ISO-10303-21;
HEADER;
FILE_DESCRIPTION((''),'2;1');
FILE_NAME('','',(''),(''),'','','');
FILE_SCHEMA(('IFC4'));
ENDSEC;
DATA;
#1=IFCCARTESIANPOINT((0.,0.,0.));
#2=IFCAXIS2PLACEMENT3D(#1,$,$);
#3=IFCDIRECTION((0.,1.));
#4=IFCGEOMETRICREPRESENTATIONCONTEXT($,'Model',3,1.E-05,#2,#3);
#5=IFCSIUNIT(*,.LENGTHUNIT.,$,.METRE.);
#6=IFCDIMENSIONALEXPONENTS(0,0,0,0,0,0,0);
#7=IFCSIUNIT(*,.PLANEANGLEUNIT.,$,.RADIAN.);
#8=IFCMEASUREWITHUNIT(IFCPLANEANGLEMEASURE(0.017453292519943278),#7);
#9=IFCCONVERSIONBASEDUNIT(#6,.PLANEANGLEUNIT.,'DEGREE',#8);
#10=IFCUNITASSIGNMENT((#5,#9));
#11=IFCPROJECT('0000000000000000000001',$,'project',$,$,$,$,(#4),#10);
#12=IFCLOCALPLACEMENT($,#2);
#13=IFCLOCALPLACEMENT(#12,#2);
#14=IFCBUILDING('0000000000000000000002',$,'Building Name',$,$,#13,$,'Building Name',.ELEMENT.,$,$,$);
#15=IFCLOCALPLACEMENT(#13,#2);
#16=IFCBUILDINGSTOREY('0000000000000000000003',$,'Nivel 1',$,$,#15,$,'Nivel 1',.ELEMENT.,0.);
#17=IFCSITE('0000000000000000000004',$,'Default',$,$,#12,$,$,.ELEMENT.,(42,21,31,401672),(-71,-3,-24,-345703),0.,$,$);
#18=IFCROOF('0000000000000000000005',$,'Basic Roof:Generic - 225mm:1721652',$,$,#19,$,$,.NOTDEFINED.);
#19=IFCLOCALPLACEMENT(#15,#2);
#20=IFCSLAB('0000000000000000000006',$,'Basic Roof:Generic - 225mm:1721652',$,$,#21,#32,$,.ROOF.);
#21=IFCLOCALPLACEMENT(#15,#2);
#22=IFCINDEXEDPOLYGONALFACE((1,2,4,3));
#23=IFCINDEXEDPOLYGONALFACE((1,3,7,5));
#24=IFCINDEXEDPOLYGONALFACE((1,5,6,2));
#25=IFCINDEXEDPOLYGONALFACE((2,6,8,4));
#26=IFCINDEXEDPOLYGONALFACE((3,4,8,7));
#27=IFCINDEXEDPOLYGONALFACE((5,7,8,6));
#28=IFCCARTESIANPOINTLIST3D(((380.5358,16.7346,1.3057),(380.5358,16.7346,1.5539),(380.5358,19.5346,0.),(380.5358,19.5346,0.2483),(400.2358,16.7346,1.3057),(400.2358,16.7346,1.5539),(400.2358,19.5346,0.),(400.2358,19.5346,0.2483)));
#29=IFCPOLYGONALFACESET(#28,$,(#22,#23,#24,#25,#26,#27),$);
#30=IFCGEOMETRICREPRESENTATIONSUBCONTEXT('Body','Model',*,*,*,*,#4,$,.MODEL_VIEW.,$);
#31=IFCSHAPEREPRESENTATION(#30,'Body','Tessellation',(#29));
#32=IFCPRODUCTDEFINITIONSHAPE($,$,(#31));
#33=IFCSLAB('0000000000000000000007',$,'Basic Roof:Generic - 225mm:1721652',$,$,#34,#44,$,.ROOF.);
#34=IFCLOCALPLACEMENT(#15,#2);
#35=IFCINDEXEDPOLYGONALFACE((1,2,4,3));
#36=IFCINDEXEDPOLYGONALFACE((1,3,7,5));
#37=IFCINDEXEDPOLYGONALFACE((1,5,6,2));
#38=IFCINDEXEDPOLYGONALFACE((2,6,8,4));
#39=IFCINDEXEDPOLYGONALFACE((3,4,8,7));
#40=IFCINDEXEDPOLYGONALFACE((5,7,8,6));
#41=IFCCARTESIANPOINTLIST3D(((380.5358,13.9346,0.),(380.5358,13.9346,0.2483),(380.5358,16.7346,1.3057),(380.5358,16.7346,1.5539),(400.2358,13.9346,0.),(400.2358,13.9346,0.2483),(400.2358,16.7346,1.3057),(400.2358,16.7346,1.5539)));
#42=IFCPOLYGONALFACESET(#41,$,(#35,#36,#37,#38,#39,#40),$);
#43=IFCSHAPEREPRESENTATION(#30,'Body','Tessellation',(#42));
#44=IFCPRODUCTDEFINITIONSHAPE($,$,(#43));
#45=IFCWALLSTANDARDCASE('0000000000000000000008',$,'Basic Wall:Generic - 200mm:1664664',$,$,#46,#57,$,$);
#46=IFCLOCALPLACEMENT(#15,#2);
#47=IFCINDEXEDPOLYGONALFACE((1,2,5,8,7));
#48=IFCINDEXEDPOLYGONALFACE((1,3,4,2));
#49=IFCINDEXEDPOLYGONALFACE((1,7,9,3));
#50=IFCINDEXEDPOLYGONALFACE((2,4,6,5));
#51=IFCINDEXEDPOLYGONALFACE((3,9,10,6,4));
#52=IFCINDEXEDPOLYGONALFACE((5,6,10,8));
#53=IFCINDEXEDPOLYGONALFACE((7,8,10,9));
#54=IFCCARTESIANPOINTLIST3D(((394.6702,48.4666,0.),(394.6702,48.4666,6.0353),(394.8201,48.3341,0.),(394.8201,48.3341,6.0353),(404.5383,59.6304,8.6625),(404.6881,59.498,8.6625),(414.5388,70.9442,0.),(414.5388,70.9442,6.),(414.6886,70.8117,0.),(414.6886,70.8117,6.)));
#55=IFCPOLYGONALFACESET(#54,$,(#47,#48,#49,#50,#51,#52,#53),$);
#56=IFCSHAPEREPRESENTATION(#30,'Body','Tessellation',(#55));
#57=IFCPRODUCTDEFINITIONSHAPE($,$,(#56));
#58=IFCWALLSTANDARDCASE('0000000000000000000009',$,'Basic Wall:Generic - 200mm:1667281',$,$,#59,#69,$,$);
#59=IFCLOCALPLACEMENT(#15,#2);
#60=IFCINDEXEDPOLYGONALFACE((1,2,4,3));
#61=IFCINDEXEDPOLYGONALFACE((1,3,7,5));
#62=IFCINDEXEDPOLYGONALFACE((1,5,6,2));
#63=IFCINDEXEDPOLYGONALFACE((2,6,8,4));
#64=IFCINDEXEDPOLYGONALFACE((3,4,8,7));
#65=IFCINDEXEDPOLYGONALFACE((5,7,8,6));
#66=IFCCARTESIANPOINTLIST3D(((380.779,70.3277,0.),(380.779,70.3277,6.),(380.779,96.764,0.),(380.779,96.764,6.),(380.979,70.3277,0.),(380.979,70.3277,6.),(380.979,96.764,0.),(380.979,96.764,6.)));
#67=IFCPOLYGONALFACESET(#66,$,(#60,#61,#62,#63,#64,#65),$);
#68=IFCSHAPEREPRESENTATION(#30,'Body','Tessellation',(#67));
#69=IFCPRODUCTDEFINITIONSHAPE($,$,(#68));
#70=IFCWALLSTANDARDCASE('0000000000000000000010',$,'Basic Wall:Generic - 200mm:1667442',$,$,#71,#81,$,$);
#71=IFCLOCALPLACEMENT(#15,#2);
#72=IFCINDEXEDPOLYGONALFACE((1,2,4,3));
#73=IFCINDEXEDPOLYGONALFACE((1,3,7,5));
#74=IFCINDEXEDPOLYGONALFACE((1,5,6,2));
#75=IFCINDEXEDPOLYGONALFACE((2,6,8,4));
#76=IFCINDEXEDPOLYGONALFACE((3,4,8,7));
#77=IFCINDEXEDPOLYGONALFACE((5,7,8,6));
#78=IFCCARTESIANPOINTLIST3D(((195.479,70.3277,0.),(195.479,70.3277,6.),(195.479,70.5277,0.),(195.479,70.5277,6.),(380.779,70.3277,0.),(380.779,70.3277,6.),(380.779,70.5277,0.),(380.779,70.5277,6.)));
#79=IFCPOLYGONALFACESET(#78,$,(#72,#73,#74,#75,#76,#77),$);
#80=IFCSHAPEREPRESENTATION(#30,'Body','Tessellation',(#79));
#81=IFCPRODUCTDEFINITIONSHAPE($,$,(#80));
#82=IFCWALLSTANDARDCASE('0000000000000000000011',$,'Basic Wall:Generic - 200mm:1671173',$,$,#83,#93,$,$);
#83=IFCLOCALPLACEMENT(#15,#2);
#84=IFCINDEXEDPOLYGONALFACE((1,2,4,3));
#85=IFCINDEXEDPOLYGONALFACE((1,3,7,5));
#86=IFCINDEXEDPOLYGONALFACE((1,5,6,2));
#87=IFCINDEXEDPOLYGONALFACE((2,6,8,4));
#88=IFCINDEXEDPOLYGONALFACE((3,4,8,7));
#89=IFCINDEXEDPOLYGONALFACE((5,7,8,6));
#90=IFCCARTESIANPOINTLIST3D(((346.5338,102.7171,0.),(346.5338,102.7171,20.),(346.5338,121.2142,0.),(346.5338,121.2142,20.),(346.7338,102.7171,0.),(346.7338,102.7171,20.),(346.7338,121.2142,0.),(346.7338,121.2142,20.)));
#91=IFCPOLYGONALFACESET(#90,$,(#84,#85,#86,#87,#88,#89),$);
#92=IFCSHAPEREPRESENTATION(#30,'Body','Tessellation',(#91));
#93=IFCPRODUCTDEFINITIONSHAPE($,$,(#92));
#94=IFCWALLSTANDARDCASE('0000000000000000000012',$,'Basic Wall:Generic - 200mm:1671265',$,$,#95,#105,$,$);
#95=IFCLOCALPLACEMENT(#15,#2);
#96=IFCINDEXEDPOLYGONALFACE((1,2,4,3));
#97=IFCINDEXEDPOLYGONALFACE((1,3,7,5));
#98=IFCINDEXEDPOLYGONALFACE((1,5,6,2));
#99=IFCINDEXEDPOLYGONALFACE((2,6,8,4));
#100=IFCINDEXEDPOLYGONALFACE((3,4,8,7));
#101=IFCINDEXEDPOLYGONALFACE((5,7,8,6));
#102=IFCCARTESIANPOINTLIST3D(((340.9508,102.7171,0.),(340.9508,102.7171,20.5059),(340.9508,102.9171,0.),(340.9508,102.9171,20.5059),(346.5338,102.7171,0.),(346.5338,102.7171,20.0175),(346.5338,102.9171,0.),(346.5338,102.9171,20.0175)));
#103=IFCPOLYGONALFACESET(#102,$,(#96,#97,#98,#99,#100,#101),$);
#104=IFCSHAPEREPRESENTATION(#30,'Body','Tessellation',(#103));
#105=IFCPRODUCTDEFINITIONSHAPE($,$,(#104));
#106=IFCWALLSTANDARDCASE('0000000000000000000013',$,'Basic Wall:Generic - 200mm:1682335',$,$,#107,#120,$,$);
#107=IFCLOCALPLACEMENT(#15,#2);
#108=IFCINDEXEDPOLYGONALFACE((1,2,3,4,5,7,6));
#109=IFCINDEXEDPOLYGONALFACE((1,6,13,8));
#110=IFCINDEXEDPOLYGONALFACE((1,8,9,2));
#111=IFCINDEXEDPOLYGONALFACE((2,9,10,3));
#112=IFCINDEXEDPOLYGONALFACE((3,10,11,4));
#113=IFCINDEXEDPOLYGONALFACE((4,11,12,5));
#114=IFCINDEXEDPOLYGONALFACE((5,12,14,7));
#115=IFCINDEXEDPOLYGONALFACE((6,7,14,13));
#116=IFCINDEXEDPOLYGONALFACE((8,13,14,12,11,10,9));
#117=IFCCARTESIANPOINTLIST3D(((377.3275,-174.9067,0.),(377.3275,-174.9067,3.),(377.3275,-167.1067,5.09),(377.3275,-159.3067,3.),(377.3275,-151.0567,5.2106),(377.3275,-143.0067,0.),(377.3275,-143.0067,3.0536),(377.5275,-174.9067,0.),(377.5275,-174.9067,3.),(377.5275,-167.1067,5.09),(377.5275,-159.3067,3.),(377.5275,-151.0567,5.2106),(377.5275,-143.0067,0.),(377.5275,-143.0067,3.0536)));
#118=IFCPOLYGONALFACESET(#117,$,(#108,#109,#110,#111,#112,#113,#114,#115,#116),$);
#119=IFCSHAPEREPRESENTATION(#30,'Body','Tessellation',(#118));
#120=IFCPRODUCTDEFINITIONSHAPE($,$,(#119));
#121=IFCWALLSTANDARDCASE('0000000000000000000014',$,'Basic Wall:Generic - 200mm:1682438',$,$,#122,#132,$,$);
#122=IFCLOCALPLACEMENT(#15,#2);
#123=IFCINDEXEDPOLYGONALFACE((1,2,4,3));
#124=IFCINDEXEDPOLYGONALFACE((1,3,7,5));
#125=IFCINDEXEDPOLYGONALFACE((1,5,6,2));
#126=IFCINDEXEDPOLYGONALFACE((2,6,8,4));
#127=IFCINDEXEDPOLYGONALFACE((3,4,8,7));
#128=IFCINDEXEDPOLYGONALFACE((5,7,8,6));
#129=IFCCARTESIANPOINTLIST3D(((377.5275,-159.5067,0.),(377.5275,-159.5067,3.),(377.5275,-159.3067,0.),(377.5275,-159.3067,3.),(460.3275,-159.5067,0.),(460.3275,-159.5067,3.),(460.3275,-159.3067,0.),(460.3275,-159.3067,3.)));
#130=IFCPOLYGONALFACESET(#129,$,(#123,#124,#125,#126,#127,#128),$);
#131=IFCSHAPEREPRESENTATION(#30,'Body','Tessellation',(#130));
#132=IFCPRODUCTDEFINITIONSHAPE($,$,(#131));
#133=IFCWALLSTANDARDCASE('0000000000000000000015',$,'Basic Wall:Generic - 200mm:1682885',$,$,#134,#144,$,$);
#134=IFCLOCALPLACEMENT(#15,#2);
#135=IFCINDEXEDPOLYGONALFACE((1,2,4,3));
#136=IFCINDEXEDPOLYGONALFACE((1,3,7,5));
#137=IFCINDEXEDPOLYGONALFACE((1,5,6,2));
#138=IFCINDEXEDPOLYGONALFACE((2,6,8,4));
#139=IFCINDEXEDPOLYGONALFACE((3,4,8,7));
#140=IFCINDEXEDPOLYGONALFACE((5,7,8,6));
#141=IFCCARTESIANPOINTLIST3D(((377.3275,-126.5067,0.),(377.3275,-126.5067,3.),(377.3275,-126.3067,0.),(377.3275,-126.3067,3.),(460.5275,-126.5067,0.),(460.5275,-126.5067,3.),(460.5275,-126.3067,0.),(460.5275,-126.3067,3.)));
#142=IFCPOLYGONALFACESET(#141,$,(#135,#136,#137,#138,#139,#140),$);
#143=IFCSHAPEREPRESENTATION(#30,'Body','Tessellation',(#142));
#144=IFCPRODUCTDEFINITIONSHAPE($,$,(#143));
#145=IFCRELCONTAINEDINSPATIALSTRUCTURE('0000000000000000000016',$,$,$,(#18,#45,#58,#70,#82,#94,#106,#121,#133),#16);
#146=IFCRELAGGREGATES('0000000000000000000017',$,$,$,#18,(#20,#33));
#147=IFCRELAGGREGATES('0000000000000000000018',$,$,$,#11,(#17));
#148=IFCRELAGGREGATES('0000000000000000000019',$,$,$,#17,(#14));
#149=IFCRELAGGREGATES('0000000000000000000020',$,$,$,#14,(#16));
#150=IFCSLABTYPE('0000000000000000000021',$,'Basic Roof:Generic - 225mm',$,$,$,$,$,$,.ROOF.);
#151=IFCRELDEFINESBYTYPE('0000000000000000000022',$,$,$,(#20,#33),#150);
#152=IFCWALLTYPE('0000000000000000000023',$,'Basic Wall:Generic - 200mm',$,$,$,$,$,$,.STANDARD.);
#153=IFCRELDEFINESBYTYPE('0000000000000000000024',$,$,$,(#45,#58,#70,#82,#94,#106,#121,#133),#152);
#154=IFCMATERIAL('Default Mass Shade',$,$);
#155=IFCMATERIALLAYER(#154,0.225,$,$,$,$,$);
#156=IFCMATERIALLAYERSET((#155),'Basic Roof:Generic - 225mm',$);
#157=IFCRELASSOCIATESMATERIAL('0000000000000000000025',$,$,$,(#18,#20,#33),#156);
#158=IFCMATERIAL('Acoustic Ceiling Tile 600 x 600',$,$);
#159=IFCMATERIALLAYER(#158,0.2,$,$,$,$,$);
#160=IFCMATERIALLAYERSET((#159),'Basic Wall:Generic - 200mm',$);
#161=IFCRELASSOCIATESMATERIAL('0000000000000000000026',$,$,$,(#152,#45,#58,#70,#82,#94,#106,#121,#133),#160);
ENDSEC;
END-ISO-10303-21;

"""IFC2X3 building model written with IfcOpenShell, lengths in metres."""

from ifc_helpers import new_model, entity, si_unit, converted_unit, direction, frame, frame_2d, origin, place, context, subcontext, project, spatial, polyline, rectangle, extrude, clip, bounded_halfspace, material, layer, layer_set, layer_usage, type_object, element, aggregate, save


model = new_model("IFC2X3")

# Units and contexts
model_context = context("Model", 3, precision=1e-05, world=origin(), true_north=direction((0.0, 1.0)))
body_context = subcontext(model_context, "Body", "Model", "MODEL_VIEW")
ifc_project = project(units=[si_unit("LENGTHUNIT", "METRE"), converted_unit("PLANEANGLEUNIT", "DEGREE", entity("IfcPlaneAngleMeasure", 0.017453292519943278), si_unit("PLANEANGLEUNIT", "RADIAN"), dimensions=[0, 0, 0, 0, 0, 0, 0])], contexts=[model_context])

# Site, building, storey
site_placement = place(None, origin())
site = spatial("IfcSite", under=ifc_project, at=site_placement, Name="Default", CompositionType="ELEMENT", RefLatitude=(42, 21, 31, 401672), RefLongitude=(-71, -3, -24, -345703), RefElevation=0.0)
building_placement = place(site_placement, origin())
building = spatial("IfcBuilding", under=site, at=building_placement, Name="Building Name", LongName="Building Name", CompositionType="ELEMENT")
storey_placement = place(building_placement, origin())
storey = spatial("IfcBuildingStorey", under=building, at=storey_placement, Name="Nivel 1", LongName="Nivel 1", CompositionType="ELEMENT", Elevation=0.0)

# Roof, slabs
ifc_material_1 = material(Name="Default Mass Shade")
ifc_layer_1 = layer(ifc_material_1, 0.225)
ifc_layer_set_1 = layer_set([ifc_layer_1], Name="Basic Roof:Generic - 225mm")
roof_placement = place(storey_placement, frame((380.5358, 13.9346, 0.0)))
roof = element("IfcRoof", 1, at=roof_placement, inside=storey, material=ifc_layer_set_1, Name="Basic Roof:Generic - 225mm:1721652", ShapeType="NOTDEFINED")
slab_type = type_object("IfcSlabType", Name="Basic Roof:Generic - 225mm", PredefinedType="ROOF")
slab_1_placement = place(roof_placement, origin())
slab_1 = element("IfcSlab", 2, at=slab_1_placement, type_object=slab_type, material=ifc_layer_set_1, Name="Basic Roof:Generic - 225mm:1721652", PredefinedType="ROOF", context=body_context, shape_type="SweptSolid", body=[
    extrude(rectangle(XDim=19.7, YDim=3.0895, at=frame_2d((0.0, 0.0), x_axis=(1.0, 0.0))), frame((9.85, 4.2, 0.6528), z_axis=(0.0, 0.422618, 0.906308), x_axis=(1.0, 0.0, 0.0)), (0.0, -0.422618, 0.906308), 0.2483),
])
slab_2_placement = place(roof_placement, origin())
slab_2 = element("IfcSlab", 3, at=slab_2_placement, type_object=slab_type, material=ifc_layer_set_1, Name="Basic Roof:Generic - 225mm:1721652", PredefinedType="ROOF", context=body_context, shape_type="SweptSolid", body=[
    extrude(rectangle(XDim=3.0895, YDim=19.7, at=frame_2d((0.0, 0.0), x_axis=(0.0, 1.0))), frame((9.85, 1.4, 0.6528), z_axis=(0.0, -0.422618, 0.906308), x_axis=(1.0, 0.0, 0.0)), (0.0, 0.422618, 0.906308), 0.2483),
])
aggregate(roof, [slab_1, slab_2])

# Walls
ifc_material_2 = material(Name="Acoustic Ceiling Tile 600 x 600")
ifc_layer_2 = layer(ifc_material_2, 0.2)
ifc_layer_set_2 = layer_set([ifc_layer_2], Name="Basic Wall:Generic - 200mm")
ifc_layer_usage_1 = layer_usage(ifc_layer_set_2, "AXIS2", "NEGATIVE", 0.1)
wall_type_1 = type_object("IfcWallType", Name="Basic Wall:Generic - 200mm", PredefinedType="STANDARD", material=ifc_layer_set_2)
wall_1_placement = place(storey_placement, frame((394.7452, 48.4003, 0.0), z_axis=(0.0, 0.0, 1.0), x_axis=(0.662284, 0.749253, 0.0)))
element("IfcWallStandardCase", 4, at=wall_1_placement, inside=storey, type_object=wall_type_1, material=ifc_layer_usage_1, Name="Basic Wall:Generic - 200mm:1664664", context=body_context, shape_type="Clipping", body=[
    clip(clip(extrude(rectangle(XDim=30.0, YDim=0.2, at=frame_2d((15.0, 0.0), x_axis=(-1.0, 0.0))), origin(), (0.0, 0.0, 1.0), 8.6625), bounded_halfspace(frame((14.9, -0.1, 8.6625), z_axis=(0.173648, 0.0, 0.984808), x_axis=(0.0, 1.0, 0.0)), False, frame((14.9, -0.1, 8.6625)), polyline([(0.0, 0.0), (15.1, 0.0), (15.1, 0.2), (0.0, 0.2), (0.0, 0.0)]))), bounded_halfspace(frame((0.0, -0.1, 6.0353), z_axis=(-0.173648, 0.0, 0.984808), x_axis=(0.0, -1.0, 0.0)), False, frame((0.0, -0.1, 6.0353)), polyline([(0.0, 0.0), (14.9, 0.0), (14.9, 0.2), (0.0, 0.2), (0.0, 0.0)]))),
])
ifc_layer_usage_2 = layer_usage(ifc_layer_set_2, "AXIS2", "NEGATIVE", 0.1)
wall_2_placement = place(storey_placement, frame((380.879, 96.764, 0.0), z_axis=(0.0, 0.0, 1.0), x_axis=(0.0, -1.0, 0.0)))
element("IfcWallStandardCase", 5, at=wall_2_placement, inside=storey, type_object=wall_type_1, material=ifc_layer_usage_2, Name="Basic Wall:Generic - 200mm:1667281", context=body_context, shape_type="SweptSolid", body=[
    extrude(rectangle(XDim=26.4364, YDim=0.2, at=frame_2d((13.2182, 0.0), x_axis=(-1.0, 0.0))), origin(), (0.0, 0.0, 1.0), 6.0),
])
ifc_layer_usage_3 = layer_usage(ifc_layer_set_2, "AXIS2", "NEGATIVE", 0.1)
wall_3_placement = place(storey_placement, frame((380.779, 70.4277, 0.0), z_axis=(0.0, 0.0, 1.0), x_axis=(-1.0, 0.0, 0.0)))
element("IfcWallStandardCase", 6, at=wall_3_placement, inside=storey, type_object=wall_type_1, material=ifc_layer_usage_3, Name="Basic Wall:Generic - 200mm:1667442", context=body_context, shape_type="SweptSolid", body=[
    extrude(rectangle(XDim=185.3, YDim=0.2, at=frame_2d((92.65, 0.0), x_axis=(-1.0, 0.0))), origin(), (0.0, 0.0, 1.0), 6.0),
])
ifc_layer_usage_4 = layer_usage(ifc_layer_set_2, "AXIS2", "NEGATIVE", 0.1)
wall_4_placement = place(storey_placement, frame((346.6338, 121.2142, 0.0), z_axis=(0.0, 0.0, 1.0), x_axis=(0.0, -1.0, 0.0)))
element("IfcWallStandardCase", 7, at=wall_4_placement, inside=storey, type_object=wall_type_1, material=ifc_layer_usage_4, Name="Basic Wall:Generic - 200mm:1671173", context=body_context, shape_type="SweptSolid", body=[
    extrude(rectangle(XDim=18.4971, YDim=0.2, at=frame_2d((9.2486, 0.0), x_axis=(-1.0, 0.0))), origin(), (0.0, 0.0, 1.0), 20.0),
])
ifc_layer_usage_5 = layer_usage(ifc_layer_set_2, "AXIS2", "NEGATIVE", 0.1)
wall_5_placement = place(storey_placement, frame((346.5338, 102.8171, 0.0), z_axis=(0.0, 0.0, 1.0), x_axis=(-1.0, 0.0, 0.0)))
element("IfcWallStandardCase", 8, at=wall_5_placement, inside=storey, type_object=wall_type_1, material=ifc_layer_usage_5, Name="Basic Wall:Generic - 200mm:1671265", context=body_context, shape_type="Clipping", body=[
    clip(extrude(rectangle(XDim=5.583, YDim=0.2, at=frame_2d((2.7915, 0.0), x_axis=(-1.0, 0.0))), origin(), (0.0, 0.0, 1.0), 20.5059), bounded_halfspace(frame((0.0, -0.1, 20.0175), z_axis=(-0.087156, 0.0, 0.996195), x_axis=(0.0, -1.0, 0.0)), False, frame((0.0, -0.1, 20.0175)), polyline([(0.0, 0.0), (5.583, 0.0), (5.583, 0.2), (0.0, 0.2), (0.0, 0.0)]))),
])
ifc_layer_usage_6 = layer_usage(ifc_layer_set_2, "AXIS2", "NEGATIVE", 0.1)
wall_6_placement = place(storey_placement, frame((377.4275, -174.9067, 0.0), z_axis=(0.0, 0.0, 1.0), x_axis=(0.0, 1.0, 0.0)))
element("IfcWallStandardCase", 9, at=wall_6_placement, inside=storey, type_object=wall_type_1, material=ifc_layer_usage_6, Name="Basic Wall:Generic - 200mm:1682335", context=body_context, shape_type="Clipping", body=[
    clip(clip(clip(clip(extrude(rectangle(XDim=31.9, YDim=0.2, at=frame_2d((15.95, 0.0), x_axis=(-1.0, 0.0))), origin(), (0.0, 0.0, 1.0), 5.2106), bounded_halfspace(frame((23.85, -0.1, 5.2106), z_axis=(0.258819, 0.0, 0.965926), x_axis=(0.0, 1.0, 0.0)), False, frame((23.85, -0.1, 5.2106)), polyline([(0.0, 0.0), (8.05, 0.0), (8.05, 0.2), (0.0, 0.2), (0.0, 0.0)]))), bounded_halfspace(frame((0.0, -0.1, 3.0), z_axis=(-0.258819, 0.0, 0.965926), x_axis=(0.0, -1.0, 0.0)), False, frame((0.0, -0.1, 3.0)), polyline([(0.0, 0.0), (7.8, 0.0), (7.8, 0.2), (0.0, 0.2), (0.0, 0.0)]))), bounded_halfspace(frame((15.6, -0.1, 3.0), z_axis=(-0.258819, 0.0, 0.965926), x_axis=(0.0, -1.0, 0.0)), False, frame((15.6, -0.1, 3.0)), polyline([(0.0, 0.0), (8.25, 0.0), (8.25, 0.2), (0.0, 0.2), (0.0, 0.0)]))), bounded_halfspace(frame((7.8, -0.1, 5.09), z_axis=(0.258819, 0.0, 0.965926), x_axis=(0.0, 1.0, 0.0)), False, frame((7.8, -0.1, 5.09)), polyline([(0.0, 0.0), (7.8, 0.0), (7.8, 0.2), (0.0, 0.2), (0.0, 0.0)]))),
])
ifc_layer_usage_7 = layer_usage(ifc_layer_set_2, "AXIS2", "NEGATIVE", 0.1)
wall_7_placement = place(storey_placement, frame((377.5275, -159.4067, 0.0)))
element("IfcWallStandardCase", 10, at=wall_7_placement, inside=storey, type_object=wall_type_1, material=ifc_layer_usage_7, Name="Basic Wall:Generic - 200mm:1682438", context=body_context, shape_type="SweptSolid", body=[
    extrude(rectangle(XDim=82.8, YDim=0.2, at=frame_2d((41.4, 0.0), x_axis=(-1.0, 0.0))), origin(), (0.0, 0.0, 1.0), 3.0),
])
ifc_layer_usage_8 = layer_usage(ifc_layer_set_2, "AXIS2", "NEGATIVE", 0.1)
wall_8_placement = place(storey_placement, frame((377.3275, -126.4067, 0.0)))
element("IfcWallStandardCase", 11, at=wall_8_placement, inside=storey, type_object=wall_type_1, material=ifc_layer_usage_8, Name="Basic Wall:Generic - 200mm:1682885", context=body_context, shape_type="SweptSolid", body=[
    extrude(rectangle(XDim=83.2, YDim=0.2, at=frame_2d((41.6, 0.0), x_axis=(-1.0, 0.0))), origin(), (0.0, 0.0, 1.0), 3.0),
])

save(model, "model.ifc")
